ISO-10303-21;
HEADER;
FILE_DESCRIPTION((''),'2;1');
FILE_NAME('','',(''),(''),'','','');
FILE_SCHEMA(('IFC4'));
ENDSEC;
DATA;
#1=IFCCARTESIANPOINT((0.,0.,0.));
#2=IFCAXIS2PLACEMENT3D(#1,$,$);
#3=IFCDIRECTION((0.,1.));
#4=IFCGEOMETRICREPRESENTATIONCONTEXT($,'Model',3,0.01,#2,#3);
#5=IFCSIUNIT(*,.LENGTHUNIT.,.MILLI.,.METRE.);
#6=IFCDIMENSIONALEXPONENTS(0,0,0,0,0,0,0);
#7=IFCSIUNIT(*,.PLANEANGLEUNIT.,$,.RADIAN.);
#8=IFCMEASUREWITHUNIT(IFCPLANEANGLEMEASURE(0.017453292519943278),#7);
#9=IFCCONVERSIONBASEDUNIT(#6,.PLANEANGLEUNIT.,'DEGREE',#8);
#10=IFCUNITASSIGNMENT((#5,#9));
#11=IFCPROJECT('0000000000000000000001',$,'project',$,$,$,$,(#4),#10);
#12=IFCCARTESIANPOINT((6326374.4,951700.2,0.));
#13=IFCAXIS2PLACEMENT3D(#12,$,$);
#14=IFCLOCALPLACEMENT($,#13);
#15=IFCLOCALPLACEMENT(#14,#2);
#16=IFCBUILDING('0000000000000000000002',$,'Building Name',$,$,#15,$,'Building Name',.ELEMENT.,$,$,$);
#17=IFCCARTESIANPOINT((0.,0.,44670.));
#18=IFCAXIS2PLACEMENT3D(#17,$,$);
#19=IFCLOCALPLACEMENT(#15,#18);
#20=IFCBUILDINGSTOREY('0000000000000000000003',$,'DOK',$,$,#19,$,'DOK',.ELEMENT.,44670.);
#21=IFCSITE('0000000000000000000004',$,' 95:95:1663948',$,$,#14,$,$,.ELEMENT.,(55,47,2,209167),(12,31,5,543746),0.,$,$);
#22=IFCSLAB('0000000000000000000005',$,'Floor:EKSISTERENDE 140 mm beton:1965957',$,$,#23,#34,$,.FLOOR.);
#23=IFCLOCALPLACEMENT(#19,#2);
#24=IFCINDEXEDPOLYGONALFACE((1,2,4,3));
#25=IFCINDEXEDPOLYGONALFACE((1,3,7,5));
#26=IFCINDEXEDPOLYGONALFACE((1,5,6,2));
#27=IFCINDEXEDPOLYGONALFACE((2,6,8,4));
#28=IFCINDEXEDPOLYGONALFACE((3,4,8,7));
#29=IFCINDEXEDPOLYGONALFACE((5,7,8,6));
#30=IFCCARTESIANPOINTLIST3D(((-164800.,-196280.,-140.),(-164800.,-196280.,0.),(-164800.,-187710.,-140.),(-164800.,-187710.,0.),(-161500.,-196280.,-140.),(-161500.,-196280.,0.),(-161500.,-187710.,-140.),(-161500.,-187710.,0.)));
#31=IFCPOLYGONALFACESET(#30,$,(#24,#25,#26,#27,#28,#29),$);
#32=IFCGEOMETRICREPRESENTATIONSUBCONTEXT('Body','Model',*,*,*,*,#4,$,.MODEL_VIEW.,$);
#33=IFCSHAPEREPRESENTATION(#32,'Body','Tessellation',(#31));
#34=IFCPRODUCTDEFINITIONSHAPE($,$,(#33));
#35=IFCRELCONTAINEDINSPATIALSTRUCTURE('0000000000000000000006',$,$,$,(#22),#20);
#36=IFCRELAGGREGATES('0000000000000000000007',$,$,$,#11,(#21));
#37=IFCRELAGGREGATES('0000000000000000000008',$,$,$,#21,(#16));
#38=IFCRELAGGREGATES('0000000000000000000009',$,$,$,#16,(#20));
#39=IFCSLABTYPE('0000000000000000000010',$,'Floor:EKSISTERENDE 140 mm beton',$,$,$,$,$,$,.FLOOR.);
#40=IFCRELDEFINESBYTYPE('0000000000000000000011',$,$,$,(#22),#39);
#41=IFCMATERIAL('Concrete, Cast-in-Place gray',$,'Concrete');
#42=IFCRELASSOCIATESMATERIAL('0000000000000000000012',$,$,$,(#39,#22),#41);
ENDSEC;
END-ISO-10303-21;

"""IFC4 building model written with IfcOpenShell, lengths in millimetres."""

from ifc_helpers import new_model, entity, si_unit, converted_unit, direction, frame, origin, place, context, subcontext, project, spatial, indexed_curve, outline, extrude, material, type_object, element, save


model = new_model("IFC4")

# Units and contexts
model_context = context("Model", 3, precision=0.01, world=origin(), true_north=direction((0.0, 1.0)))
body_context = subcontext(model_context, "Body", "Model", "MODEL_VIEW")
ifc_project = project(units=[si_unit("LENGTHUNIT", "METRE", prefix="MILLI"), converted_unit("PLANEANGLEUNIT", "DEGREE", entity("IfcPlaneAngleMeasure", 0.017453292519943278), si_unit("PLANEANGLEUNIT", "RADIAN"), dimensions=[0, 0, 0, 0, 0, 0, 0])], contexts=[model_context])

# Site, building, storey
site_placement = place(None, frame((6326374.4, 951700.2, 0.0)))
site = spatial("IfcSite", under=ifc_project, at=site_placement, Name=" 95:95:1663948", CompositionType="ELEMENT", RefLatitude=(55, 47, 2, 209167), RefLongitude=(12, 31, 5, 543746), RefElevation=0.0)
building_placement = place(site_placement, origin())
building = spatial("IfcBuilding", under=site, at=building_placement, Name="Building Name", LongName="Building Name", CompositionType="ELEMENT")
storey_placement = place(building_placement, frame((0.0, 0.0, 44670.0)))
storey = spatial("IfcBuildingStorey", under=building, at=storey_placement, Name="DOK", LongName="DOK", CompositionType="ELEMENT", Elevation=44670.0)

# Slab
ifc_material = material(Name="Concrete, Cast-in-Place gray", Category="Concrete")
slab_type_1 = type_object("IfcSlabType", Name="Floor:EKSISTERENDE 140 mm beton", PredefinedType="FLOOR", material=ifc_material)
slab_1_placement = place(storey_placement, origin())
element("IfcSlab", 1, at=slab_1_placement, inside=storey, type_object=slab_type_1, material=ifc_material, Name="Floor:EKSISTERENDE 140 mm beton:1965957", PredefinedType="FLOOR", context=body_context, shape_type="SweptSolid", body=[
    extrude(outline(indexed_curve([(-4285.0, -1650.0), (4285.0, -1650.0), (4285.0, 1650.0), (-4285.0, 1650.0), (-4285.0, -1650.0)], self_intersect=False)), frame((-163150.0, -191995.0, 0.0), z_axis=(0.0, 0.0, -1.0), x_axis=(0.0, 1.0, 0.0)), (0.0, 0.0, 1.0), 140.0),
])

save(model, "model.ifc")
